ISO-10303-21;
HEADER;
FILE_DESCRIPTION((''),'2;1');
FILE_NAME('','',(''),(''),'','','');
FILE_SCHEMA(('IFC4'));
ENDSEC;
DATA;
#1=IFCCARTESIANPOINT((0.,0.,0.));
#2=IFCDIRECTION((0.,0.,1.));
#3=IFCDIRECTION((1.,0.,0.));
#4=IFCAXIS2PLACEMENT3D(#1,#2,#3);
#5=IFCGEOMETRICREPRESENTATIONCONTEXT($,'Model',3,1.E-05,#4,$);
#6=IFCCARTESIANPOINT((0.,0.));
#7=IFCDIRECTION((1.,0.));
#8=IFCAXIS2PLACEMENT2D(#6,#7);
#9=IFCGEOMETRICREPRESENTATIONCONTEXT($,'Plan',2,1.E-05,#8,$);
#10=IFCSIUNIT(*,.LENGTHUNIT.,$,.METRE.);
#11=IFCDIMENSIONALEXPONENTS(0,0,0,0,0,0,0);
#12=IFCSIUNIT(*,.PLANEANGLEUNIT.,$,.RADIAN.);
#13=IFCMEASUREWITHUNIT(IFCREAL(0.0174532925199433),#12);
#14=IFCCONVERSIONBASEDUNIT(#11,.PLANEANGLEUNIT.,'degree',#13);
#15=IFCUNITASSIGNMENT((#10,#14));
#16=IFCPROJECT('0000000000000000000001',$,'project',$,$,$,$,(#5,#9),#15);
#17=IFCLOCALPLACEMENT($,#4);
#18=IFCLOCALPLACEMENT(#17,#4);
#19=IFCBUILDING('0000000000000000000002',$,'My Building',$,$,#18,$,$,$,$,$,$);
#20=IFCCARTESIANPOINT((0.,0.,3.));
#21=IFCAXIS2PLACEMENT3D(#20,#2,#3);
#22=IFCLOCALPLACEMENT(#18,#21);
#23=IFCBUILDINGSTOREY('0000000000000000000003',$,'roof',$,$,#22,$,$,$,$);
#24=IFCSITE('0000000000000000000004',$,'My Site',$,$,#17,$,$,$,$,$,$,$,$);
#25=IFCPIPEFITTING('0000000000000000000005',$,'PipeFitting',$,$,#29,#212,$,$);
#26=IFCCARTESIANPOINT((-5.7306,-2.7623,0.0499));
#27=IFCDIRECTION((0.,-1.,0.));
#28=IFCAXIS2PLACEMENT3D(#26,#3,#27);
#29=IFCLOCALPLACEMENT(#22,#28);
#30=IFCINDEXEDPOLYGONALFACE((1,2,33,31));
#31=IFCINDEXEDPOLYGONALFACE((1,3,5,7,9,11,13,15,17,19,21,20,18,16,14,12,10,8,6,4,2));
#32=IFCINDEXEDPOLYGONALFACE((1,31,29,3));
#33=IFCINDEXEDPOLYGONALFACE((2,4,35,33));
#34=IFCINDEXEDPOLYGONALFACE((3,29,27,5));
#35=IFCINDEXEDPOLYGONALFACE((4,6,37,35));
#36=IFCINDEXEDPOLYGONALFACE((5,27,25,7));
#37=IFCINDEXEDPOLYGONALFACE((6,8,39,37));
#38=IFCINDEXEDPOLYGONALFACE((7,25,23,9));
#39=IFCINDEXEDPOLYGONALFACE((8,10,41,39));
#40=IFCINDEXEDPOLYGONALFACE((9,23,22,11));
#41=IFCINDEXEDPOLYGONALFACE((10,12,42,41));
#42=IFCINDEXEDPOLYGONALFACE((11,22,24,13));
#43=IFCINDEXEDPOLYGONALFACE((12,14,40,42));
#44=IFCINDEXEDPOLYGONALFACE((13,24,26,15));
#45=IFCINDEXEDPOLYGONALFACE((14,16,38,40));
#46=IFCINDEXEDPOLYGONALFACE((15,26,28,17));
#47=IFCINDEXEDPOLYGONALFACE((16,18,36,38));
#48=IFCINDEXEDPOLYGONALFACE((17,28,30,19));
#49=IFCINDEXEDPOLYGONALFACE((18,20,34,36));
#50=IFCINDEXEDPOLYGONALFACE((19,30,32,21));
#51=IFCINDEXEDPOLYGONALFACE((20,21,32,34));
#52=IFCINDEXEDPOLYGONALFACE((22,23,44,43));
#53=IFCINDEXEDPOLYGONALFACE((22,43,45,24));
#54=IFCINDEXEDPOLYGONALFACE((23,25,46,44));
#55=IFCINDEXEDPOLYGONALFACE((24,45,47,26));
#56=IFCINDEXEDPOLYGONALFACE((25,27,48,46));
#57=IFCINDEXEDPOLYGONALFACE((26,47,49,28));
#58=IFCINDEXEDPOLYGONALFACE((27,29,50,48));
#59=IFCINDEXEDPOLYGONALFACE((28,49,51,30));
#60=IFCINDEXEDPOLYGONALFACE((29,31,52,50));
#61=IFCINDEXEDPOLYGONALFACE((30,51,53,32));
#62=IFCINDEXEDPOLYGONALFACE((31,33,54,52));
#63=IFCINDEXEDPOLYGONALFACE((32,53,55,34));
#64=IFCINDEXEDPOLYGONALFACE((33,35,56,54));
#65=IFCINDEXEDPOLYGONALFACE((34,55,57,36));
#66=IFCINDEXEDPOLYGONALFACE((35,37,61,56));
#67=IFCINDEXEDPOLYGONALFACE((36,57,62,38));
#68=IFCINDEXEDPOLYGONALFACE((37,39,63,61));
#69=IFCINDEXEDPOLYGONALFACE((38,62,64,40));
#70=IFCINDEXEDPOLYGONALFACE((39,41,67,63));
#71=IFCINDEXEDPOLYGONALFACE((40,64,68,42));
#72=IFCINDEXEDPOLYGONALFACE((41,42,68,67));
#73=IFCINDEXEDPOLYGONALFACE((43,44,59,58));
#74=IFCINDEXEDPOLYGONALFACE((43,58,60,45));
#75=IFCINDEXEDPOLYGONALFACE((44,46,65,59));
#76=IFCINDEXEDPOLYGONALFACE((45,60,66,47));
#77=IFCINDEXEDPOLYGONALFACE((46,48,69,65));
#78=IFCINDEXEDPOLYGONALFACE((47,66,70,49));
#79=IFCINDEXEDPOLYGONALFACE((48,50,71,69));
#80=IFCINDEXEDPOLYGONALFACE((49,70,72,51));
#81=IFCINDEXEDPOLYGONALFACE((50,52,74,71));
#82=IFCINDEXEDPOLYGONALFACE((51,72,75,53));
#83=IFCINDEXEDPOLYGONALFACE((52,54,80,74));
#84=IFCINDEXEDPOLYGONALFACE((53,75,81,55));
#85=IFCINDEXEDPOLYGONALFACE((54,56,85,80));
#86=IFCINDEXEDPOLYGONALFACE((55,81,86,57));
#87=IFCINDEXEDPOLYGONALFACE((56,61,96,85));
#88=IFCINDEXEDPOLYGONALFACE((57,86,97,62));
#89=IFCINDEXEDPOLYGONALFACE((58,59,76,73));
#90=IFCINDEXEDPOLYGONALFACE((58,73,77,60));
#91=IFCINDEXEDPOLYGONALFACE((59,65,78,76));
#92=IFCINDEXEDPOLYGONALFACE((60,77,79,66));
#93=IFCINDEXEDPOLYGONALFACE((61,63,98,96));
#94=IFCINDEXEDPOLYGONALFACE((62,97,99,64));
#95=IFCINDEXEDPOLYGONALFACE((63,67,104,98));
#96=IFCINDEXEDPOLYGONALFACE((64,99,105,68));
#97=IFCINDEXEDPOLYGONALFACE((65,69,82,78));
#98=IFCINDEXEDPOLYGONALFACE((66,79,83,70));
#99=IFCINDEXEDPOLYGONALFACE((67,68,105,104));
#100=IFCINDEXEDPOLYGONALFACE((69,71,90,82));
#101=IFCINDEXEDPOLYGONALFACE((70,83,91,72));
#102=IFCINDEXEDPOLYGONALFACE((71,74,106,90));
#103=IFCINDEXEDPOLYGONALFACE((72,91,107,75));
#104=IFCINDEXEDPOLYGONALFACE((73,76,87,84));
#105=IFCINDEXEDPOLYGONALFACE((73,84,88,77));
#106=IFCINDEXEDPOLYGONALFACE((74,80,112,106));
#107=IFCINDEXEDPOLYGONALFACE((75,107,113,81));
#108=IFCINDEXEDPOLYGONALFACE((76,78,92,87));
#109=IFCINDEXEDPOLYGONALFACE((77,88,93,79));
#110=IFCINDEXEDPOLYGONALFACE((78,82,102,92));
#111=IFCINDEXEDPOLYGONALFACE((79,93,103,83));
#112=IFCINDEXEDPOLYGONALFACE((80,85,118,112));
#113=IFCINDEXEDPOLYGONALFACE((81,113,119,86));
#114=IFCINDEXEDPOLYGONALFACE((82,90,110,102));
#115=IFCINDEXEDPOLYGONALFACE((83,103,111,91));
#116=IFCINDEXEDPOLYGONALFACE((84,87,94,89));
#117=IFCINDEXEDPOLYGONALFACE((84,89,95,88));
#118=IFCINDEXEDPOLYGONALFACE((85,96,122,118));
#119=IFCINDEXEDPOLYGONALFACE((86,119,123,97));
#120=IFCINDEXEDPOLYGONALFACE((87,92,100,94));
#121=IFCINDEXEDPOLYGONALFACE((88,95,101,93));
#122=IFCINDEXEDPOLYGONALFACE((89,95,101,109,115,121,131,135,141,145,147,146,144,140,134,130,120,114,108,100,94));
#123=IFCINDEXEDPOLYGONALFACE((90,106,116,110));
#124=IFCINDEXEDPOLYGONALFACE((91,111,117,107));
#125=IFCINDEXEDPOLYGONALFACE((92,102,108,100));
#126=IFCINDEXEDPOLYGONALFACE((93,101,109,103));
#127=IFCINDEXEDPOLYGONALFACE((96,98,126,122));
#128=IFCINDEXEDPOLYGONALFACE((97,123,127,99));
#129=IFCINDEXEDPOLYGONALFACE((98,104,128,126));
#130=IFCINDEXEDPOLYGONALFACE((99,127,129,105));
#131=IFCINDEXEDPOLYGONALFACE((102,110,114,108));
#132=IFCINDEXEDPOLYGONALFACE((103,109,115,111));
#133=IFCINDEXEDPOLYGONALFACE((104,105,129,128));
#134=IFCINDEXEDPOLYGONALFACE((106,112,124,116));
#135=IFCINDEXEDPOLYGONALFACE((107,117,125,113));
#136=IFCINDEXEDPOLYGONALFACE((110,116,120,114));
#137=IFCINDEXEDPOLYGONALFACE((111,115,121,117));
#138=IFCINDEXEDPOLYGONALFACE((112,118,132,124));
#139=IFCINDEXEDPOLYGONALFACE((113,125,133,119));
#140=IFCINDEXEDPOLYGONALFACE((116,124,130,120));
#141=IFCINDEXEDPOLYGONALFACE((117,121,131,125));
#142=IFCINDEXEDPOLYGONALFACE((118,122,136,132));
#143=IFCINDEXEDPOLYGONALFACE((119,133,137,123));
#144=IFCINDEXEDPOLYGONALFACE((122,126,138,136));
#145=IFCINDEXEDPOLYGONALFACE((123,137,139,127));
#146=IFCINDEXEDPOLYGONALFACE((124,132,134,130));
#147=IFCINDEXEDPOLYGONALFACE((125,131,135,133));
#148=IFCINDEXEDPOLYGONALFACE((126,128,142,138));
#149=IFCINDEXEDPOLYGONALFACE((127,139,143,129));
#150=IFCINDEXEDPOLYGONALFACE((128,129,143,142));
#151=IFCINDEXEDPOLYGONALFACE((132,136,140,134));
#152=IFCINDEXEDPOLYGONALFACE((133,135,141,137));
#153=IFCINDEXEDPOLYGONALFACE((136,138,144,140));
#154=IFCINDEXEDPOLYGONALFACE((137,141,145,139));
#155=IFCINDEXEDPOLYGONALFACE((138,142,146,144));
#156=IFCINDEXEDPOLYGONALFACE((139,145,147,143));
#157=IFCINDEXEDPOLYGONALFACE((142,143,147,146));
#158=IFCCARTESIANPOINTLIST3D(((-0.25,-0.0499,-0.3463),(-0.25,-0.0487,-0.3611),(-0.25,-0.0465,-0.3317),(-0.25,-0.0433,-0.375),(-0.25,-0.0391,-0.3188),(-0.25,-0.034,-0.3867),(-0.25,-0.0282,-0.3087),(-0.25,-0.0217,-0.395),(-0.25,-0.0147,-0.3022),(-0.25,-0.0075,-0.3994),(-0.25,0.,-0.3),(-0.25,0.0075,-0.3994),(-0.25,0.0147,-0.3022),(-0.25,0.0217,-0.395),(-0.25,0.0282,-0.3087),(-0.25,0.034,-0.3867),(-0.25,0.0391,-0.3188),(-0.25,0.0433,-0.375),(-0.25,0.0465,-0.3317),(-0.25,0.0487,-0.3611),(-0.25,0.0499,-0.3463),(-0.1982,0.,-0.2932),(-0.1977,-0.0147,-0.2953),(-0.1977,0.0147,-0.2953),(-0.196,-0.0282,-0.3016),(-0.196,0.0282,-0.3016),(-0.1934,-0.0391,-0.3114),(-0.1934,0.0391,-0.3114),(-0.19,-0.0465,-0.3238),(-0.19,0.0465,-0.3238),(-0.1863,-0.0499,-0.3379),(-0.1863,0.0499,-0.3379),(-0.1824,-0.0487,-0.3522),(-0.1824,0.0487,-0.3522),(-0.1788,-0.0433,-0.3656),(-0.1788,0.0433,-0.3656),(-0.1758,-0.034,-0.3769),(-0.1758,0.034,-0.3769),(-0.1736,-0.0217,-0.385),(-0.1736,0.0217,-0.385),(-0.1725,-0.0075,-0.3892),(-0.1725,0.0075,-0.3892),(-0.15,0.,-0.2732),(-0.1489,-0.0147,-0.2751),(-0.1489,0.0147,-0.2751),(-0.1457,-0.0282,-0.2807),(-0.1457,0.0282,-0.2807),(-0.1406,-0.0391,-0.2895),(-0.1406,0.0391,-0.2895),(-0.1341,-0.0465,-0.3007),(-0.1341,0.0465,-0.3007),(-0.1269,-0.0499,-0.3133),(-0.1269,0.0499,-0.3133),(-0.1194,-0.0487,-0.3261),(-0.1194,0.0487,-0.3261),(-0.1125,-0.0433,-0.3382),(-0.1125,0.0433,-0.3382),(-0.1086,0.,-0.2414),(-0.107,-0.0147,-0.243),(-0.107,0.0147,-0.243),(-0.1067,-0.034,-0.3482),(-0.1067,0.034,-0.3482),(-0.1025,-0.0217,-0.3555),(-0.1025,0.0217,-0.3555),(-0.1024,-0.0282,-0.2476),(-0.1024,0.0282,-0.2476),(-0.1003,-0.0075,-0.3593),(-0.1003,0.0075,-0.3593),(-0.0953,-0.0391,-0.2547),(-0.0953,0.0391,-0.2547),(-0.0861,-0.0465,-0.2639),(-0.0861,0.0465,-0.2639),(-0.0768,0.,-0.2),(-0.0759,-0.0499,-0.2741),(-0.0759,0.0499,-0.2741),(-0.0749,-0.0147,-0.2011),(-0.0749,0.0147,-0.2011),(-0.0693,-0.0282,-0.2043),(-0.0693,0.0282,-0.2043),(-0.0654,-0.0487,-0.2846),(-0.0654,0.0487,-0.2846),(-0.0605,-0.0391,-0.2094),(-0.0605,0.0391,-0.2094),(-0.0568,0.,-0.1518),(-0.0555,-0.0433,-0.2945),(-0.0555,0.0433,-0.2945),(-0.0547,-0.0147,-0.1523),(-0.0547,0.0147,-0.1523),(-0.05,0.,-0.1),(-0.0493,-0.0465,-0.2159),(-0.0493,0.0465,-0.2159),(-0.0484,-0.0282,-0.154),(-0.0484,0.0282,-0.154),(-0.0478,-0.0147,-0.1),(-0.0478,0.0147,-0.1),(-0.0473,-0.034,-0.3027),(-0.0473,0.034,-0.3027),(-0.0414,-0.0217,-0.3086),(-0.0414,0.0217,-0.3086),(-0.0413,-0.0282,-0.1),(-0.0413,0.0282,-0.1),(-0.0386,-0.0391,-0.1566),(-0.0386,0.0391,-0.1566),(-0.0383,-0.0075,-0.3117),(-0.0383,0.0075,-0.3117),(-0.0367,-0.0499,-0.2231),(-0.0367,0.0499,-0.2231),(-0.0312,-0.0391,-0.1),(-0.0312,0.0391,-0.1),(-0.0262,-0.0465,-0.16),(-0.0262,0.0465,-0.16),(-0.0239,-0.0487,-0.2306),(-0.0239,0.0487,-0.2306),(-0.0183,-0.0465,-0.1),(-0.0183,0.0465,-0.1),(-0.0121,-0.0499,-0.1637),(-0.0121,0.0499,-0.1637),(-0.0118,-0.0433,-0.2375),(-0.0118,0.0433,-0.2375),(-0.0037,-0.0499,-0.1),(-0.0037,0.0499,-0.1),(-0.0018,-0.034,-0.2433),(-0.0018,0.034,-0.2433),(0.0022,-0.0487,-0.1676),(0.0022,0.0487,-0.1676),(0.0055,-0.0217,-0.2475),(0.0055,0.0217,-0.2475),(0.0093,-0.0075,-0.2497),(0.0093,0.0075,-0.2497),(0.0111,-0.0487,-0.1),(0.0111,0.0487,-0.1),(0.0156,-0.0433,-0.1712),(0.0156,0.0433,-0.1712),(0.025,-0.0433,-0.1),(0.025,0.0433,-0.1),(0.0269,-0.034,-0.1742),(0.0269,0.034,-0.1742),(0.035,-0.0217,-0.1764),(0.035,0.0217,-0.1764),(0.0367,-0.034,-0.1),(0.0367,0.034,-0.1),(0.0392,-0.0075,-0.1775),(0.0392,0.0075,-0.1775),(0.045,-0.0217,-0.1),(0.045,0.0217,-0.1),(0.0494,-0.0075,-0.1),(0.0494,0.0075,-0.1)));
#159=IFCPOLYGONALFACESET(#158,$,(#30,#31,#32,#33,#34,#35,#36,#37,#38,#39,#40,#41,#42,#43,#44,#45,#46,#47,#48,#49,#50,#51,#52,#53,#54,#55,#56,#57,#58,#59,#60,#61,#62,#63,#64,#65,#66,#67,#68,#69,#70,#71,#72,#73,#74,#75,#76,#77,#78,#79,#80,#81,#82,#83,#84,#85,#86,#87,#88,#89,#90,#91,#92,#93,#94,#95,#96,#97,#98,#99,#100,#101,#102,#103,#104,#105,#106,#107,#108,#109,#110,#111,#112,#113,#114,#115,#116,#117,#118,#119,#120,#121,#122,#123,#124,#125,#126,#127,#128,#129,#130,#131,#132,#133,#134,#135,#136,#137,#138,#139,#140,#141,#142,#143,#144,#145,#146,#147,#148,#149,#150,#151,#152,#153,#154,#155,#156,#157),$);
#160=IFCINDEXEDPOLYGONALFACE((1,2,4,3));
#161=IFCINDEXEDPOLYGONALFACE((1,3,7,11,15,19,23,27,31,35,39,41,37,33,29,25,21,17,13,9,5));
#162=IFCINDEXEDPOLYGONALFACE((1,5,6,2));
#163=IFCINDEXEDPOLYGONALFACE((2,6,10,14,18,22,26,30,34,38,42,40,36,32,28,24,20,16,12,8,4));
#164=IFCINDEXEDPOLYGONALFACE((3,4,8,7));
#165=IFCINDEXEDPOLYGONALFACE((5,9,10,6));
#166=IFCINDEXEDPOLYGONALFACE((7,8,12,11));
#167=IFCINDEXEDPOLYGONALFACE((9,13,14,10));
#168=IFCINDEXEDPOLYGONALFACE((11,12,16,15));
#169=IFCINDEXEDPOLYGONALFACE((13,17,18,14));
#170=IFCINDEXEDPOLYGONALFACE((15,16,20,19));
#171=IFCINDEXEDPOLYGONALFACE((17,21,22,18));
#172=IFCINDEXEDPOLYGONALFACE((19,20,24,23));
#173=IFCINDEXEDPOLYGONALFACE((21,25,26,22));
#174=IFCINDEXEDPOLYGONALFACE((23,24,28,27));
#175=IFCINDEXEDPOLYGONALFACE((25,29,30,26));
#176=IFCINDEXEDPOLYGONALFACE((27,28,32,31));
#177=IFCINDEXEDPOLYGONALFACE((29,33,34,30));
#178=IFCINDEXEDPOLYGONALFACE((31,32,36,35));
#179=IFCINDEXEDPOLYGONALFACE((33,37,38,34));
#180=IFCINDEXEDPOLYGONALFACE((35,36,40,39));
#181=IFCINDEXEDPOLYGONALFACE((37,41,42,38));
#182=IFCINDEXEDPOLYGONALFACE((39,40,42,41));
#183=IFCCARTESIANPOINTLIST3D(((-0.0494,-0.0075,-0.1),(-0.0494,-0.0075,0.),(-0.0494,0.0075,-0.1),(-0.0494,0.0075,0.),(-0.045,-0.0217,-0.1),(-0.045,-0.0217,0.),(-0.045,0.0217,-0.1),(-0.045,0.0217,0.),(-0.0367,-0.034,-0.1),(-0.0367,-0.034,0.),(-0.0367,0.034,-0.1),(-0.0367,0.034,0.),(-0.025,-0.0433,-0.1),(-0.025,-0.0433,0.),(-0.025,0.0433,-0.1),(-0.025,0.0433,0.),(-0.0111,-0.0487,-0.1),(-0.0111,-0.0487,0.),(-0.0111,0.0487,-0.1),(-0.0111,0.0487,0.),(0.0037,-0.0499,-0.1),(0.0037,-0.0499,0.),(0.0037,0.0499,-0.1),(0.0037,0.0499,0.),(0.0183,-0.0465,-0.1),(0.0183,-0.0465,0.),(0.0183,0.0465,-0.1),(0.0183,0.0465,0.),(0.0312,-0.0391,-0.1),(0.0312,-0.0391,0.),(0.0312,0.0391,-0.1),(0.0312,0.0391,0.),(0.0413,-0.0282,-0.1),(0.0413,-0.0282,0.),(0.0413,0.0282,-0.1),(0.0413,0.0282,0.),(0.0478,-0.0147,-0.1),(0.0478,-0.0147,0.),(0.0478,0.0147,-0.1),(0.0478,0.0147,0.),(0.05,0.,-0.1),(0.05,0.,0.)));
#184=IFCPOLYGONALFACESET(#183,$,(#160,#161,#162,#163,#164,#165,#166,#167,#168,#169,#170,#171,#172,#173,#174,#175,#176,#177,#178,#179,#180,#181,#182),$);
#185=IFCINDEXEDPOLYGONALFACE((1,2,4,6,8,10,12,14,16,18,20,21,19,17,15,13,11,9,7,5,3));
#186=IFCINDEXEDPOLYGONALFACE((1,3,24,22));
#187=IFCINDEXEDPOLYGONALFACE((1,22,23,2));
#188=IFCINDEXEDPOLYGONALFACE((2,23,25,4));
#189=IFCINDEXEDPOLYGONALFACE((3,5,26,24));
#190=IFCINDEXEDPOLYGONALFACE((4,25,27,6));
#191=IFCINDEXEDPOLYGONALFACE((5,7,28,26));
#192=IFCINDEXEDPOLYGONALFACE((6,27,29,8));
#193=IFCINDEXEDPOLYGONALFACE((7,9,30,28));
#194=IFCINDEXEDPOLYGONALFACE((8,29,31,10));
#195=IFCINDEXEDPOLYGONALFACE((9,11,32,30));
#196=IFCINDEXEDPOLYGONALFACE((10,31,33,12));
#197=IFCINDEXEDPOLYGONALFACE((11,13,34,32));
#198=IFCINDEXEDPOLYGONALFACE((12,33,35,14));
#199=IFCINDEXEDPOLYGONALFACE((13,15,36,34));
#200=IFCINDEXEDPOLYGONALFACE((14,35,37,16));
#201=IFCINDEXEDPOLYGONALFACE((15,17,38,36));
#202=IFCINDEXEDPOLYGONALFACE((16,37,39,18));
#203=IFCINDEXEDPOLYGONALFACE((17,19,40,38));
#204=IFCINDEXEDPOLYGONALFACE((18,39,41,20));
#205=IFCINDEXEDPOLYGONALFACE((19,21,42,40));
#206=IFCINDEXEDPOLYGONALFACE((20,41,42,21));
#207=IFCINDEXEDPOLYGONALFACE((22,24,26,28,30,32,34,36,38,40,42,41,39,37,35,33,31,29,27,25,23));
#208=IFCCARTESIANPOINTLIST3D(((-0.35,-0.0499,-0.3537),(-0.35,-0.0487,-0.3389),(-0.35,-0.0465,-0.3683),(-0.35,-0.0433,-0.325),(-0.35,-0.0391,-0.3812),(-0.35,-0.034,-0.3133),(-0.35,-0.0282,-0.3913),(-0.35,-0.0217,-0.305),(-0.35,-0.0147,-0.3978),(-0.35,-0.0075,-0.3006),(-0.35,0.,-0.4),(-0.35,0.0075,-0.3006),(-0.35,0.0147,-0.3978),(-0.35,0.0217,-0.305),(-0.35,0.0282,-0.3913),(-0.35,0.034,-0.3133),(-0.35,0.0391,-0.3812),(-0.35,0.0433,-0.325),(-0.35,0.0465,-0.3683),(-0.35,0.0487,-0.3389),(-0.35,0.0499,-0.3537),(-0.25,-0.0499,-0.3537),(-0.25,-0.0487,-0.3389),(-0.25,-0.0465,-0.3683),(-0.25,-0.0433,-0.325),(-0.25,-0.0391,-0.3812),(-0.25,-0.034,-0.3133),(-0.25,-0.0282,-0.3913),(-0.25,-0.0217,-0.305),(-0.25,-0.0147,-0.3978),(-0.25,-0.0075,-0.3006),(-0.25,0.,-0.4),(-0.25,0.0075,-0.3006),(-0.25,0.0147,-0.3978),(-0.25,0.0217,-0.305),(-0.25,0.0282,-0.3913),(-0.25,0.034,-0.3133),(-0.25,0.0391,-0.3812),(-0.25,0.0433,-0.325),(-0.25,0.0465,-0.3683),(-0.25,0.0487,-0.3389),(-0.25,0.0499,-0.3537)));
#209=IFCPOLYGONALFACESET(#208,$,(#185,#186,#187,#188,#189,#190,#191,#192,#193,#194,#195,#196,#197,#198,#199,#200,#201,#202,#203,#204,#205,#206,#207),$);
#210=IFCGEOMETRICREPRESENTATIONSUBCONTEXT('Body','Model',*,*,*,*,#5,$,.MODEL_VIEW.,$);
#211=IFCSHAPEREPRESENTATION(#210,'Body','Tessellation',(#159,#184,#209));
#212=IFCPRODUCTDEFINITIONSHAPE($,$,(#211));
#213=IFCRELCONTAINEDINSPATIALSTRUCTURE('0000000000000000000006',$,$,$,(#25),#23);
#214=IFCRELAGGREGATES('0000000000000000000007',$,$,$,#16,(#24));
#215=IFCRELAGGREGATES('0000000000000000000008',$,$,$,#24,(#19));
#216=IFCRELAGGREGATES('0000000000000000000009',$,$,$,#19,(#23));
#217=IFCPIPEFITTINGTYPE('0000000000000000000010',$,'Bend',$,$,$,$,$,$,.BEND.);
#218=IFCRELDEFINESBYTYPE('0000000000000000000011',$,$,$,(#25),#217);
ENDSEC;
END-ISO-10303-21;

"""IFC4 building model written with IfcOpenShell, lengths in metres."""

from ifc_helpers import new_model, entity, si_unit, converted_unit, frame, origin_with_axes, origin_2d_with_axis, place, context, subcontext, project, spatial, circle, extrude, source, transform, mapped, type_object, type_shapes, element, save


model = new_model("IFC4")

# Units and contexts
model_context = context("Model", 3, precision=1e-05, world=origin_with_axes())
plan_context = context("Plan", 2, precision=1e-05, world=origin_2d_with_axis())
body_context = subcontext(model_context, "Body", "Model", "MODEL_VIEW")
ifc_project = project(units=[si_unit("LENGTHUNIT", "METRE"), converted_unit("PLANEANGLEUNIT", "degree", entity("IfcReal", 0.0174532925199433), si_unit("PLANEANGLEUNIT", "RADIAN"), dimensions=[0, 0, 0, 0, 0, 0, 0])], contexts=[model_context, plan_context])

# Site, building, storey
site_placement = place(None, origin_with_axes())
site = spatial("IfcSite", under=ifc_project, at=site_placement, Name="My Site")
building_placement = place(site_placement, origin_with_axes())
building = spatial("IfcBuilding", under=site, at=building_placement, Name="My Building")
storey_placement = place(building_placement, frame((0.0, 0.0, 3.0), z_axis=(0.0, 0.0, 1.0), x_axis=(1.0, 0.0, 0.0)))
storey = spatial("IfcBuildingStorey", under=building, at=storey_placement, Name="roof")

# Pipe fitting
pipe_fitting_type_1 = type_object("IfcPipeFittingType", Name="Bend", PredefinedType="BEND")
shared_shape_1 = source(origin_with_axes(), body_context, "Body", "SolidModel", [
    entity("IfcSweptDiskSolid", entity("IfcIndexedPolyCurve", entity("IfcCartesianPointList3D", [[0.0, 0.0, -0.1], [-0.0732, 0.0, -0.2768], [-0.25, 0.0, -0.35]]), [entity("IfcArcIndex", [1, 2, 3])]), 0.05),
    extrude(circle(Radius=0.05), origin_with_axes(), (0.0, 0.0, -1.0), 0.1),
    extrude(circle(Radius=0.05), frame((-0.25, 0.0, -0.35), z_axis=(-1.0, 0.0, 0.0), x_axis=(0.0, 0.0, -1.0)), (0.0, 0.0, 1.0), 0.1),
])
type_shapes(pipe_fitting_type_1, [shared_shape_1])
for number, where, z_axis, x_axis, name in (
    (1, (-5.7306, -2.7623, 0.0499), (1.0, 0.0, 0.0), (0.0, -1.0, 0.0), "PipeFitting"),
):
    element("IfcPipeFitting", number, at=place(storey_placement, frame(where, z_axis=z_axis, x_axis=x_axis)), inside=storey, type_object=pipe_fitting_type_1, Name=name, context=body_context, shape_type="MappedRepresentation", body=[
        mapped(shared_shape_1, transform((0.0, 0.0, 0.0), x_axis=(1.0, 0.0, 0.0), y_axis=(0.0, 1.0, 0.0), z_axis=(0.0, 0.0, 1.0), scale=1.0)),
    ])

save(model, "model.ifc")
